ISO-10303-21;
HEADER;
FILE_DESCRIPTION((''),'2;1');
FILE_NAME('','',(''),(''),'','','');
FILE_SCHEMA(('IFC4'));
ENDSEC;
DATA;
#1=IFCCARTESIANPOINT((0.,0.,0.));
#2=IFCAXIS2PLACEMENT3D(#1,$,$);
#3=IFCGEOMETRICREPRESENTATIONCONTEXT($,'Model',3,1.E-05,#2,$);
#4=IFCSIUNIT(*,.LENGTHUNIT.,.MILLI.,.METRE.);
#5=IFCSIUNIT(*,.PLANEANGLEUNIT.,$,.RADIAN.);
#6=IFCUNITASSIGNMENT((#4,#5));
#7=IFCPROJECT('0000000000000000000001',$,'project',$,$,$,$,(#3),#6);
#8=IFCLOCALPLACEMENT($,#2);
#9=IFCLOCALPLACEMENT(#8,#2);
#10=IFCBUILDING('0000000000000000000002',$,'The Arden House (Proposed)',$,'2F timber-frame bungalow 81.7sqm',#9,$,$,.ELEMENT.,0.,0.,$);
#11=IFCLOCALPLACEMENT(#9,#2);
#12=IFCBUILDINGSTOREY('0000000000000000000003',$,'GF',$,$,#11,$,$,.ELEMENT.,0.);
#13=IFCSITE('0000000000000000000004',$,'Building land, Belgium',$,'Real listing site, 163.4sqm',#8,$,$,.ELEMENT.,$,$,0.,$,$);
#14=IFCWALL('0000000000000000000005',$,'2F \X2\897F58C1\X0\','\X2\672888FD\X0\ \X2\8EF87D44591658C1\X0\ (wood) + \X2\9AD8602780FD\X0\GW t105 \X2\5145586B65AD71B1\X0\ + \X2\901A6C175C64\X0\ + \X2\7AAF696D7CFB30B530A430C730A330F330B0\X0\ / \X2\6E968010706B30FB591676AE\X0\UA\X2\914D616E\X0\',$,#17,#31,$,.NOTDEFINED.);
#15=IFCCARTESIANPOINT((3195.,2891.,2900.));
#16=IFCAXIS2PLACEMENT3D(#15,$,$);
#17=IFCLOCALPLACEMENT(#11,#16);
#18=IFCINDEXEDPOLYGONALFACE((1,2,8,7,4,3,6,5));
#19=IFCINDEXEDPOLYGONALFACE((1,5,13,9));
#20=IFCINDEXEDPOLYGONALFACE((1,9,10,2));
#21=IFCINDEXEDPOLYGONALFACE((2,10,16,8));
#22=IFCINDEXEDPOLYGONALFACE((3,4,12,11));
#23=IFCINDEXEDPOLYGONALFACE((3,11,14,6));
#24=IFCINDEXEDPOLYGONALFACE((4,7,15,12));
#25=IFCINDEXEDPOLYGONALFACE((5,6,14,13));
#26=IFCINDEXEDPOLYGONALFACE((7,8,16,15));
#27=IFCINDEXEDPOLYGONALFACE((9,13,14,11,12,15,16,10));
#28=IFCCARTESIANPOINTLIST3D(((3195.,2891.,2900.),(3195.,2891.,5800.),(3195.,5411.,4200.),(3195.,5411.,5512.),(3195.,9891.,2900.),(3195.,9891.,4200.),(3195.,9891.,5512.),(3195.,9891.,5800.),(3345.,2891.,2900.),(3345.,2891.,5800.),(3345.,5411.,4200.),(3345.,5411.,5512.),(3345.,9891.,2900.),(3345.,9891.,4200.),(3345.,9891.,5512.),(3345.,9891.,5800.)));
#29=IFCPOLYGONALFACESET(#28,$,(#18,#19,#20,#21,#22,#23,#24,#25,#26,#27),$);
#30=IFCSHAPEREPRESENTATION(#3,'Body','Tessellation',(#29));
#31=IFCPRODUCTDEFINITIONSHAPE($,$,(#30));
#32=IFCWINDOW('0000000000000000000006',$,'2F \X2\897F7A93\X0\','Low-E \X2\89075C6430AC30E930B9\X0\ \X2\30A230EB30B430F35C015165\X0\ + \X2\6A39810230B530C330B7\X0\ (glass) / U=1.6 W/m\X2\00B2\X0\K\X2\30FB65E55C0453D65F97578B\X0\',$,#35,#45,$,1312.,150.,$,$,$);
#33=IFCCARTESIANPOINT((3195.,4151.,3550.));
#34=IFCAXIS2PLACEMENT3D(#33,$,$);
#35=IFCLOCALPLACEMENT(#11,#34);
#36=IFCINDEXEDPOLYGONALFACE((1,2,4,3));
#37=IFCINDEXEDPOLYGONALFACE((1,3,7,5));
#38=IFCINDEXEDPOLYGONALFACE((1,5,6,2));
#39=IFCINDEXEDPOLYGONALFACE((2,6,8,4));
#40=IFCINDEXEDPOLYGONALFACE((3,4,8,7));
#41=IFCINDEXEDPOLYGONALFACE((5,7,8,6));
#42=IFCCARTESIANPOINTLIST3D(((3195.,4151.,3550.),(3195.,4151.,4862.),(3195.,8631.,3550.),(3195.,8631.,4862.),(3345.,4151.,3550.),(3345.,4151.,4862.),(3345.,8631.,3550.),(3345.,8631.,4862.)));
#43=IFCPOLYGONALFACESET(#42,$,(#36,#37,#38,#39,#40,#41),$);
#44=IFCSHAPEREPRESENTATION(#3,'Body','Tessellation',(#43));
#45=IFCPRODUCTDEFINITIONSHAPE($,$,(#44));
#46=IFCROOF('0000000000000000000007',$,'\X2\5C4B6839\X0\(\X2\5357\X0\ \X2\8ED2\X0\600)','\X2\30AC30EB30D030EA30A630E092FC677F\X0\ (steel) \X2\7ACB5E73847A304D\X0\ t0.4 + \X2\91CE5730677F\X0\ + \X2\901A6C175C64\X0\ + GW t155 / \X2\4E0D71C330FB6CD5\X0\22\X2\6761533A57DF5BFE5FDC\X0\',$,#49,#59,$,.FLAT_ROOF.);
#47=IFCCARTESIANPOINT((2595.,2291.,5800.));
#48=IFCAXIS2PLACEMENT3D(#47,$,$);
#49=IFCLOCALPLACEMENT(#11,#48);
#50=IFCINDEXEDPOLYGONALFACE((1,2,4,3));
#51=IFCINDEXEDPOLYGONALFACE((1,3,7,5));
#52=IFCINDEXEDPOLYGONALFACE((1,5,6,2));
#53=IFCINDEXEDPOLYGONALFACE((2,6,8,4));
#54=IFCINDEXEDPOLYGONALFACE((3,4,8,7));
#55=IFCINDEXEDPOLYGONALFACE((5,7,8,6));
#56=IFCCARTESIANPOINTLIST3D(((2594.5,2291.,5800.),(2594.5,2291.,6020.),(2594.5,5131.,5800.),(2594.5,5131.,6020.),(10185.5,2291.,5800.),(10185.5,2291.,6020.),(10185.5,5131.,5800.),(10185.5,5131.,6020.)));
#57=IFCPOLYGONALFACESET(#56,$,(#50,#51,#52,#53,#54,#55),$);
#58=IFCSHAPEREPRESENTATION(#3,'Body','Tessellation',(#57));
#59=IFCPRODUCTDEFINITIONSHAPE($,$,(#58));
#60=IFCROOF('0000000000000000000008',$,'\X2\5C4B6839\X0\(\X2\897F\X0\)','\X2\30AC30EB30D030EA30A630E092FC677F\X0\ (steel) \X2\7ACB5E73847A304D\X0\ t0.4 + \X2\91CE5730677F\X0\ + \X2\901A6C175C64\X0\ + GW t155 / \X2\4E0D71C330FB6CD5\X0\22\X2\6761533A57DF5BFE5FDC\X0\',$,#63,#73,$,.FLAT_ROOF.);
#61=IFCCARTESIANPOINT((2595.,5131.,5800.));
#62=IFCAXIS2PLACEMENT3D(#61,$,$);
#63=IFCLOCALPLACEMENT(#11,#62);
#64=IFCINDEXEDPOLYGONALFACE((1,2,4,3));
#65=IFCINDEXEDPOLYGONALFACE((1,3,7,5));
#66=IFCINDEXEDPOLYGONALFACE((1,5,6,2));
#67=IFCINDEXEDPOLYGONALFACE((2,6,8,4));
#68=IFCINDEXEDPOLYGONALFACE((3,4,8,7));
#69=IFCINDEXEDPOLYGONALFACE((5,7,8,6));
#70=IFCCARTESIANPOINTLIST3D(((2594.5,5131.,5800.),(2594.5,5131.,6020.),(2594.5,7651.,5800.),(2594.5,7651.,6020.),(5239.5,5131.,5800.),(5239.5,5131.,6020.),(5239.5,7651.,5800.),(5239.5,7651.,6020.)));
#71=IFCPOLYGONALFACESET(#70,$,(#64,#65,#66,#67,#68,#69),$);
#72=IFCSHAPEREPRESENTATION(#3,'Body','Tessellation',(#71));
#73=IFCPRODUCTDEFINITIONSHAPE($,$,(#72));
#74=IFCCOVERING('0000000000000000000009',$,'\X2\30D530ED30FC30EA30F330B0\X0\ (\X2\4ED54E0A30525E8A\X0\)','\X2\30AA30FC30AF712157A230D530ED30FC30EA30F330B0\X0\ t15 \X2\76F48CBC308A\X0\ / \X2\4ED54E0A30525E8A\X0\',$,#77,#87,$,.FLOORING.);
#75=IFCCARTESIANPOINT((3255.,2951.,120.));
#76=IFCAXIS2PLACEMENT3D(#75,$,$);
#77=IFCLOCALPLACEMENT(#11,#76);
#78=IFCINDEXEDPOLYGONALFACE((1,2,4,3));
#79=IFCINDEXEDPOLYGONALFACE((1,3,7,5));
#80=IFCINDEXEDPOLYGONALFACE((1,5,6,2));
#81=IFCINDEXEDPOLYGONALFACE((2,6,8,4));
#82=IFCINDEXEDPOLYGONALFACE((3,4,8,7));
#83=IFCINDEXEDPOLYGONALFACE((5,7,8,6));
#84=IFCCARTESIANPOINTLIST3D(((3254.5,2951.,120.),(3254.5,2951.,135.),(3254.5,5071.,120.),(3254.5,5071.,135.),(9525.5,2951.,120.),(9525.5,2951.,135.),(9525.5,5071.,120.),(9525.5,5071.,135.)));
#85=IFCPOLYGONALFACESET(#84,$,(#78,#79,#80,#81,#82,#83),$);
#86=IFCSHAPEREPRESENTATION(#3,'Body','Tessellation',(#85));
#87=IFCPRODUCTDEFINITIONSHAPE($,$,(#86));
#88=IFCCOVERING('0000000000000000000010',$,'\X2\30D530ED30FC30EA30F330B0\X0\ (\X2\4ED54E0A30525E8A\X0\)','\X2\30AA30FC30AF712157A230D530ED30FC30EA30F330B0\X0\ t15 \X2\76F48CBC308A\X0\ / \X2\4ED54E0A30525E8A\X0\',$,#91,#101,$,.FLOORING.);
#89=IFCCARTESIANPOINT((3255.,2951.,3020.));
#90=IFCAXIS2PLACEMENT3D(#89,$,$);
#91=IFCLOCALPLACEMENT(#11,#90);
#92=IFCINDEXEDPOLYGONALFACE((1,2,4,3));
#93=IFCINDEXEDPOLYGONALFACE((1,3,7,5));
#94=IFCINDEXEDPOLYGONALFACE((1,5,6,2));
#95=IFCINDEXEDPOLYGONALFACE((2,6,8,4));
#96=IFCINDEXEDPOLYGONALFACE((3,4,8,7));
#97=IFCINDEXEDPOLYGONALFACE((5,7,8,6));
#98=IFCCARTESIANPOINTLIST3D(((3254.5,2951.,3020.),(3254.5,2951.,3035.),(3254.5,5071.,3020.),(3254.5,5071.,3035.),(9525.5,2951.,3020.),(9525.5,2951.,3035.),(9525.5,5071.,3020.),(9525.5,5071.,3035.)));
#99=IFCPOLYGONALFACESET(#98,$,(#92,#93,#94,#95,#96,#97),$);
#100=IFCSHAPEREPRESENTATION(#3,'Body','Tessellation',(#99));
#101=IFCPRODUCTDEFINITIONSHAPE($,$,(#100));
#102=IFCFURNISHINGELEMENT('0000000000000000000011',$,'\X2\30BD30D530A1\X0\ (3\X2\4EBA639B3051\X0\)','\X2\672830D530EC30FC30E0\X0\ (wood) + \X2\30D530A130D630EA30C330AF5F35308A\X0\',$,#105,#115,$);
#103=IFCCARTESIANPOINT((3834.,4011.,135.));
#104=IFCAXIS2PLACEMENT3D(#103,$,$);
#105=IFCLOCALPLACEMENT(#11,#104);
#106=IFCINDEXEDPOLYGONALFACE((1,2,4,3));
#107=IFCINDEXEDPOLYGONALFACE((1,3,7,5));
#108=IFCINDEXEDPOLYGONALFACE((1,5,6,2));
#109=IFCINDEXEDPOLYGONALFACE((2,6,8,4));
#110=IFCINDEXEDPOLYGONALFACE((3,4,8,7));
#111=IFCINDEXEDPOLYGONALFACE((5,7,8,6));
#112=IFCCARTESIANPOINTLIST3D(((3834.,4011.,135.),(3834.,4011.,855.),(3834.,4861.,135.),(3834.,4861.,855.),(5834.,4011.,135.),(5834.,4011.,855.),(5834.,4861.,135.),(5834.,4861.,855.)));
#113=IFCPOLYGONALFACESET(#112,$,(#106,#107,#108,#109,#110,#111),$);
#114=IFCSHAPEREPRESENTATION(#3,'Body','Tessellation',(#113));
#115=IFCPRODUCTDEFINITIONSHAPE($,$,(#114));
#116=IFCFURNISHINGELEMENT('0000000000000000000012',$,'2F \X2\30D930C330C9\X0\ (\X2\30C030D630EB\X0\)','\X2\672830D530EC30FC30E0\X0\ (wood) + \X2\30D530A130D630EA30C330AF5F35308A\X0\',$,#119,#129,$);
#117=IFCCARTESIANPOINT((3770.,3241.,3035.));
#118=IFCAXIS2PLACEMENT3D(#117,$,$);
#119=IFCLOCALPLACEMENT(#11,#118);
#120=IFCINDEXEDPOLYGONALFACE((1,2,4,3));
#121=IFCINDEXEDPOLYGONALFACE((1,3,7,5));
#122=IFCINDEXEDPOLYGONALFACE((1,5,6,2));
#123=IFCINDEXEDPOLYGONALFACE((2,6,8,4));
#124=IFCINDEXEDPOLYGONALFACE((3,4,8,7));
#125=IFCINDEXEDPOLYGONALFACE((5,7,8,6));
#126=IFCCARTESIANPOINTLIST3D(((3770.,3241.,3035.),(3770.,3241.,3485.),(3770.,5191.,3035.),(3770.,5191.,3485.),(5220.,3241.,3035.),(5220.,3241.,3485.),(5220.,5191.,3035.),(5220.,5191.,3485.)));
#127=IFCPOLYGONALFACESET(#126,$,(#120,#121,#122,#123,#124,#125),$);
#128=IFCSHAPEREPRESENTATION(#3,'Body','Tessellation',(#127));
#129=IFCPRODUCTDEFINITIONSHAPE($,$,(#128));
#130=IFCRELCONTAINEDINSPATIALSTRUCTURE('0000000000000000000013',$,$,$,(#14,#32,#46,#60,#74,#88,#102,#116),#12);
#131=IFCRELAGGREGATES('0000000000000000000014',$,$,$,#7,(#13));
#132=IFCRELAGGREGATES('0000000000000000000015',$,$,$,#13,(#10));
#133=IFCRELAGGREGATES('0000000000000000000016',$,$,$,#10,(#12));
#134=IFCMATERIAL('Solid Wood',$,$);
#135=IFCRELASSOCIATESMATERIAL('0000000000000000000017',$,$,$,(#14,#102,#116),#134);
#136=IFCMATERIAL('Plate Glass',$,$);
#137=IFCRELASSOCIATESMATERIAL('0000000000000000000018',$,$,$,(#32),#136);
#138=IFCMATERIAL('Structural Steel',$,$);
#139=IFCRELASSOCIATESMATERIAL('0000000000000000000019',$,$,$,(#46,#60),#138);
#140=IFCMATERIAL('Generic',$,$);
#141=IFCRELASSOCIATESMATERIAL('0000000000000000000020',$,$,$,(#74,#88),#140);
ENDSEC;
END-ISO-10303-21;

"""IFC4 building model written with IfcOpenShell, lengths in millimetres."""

from ifc_helpers import new_model, si_unit, frame, frame_2d, origin, place, context, project, spatial, rectangle, extrude, material, element, fill, save


model = new_model("IFC4")

# Units and contexts
model_context = context("Model", 3, precision=1e-05, world=origin())
ifc_project = project(units=[si_unit("LENGTHUNIT", "METRE", prefix="MILLI"), si_unit("PLANEANGLEUNIT", "RADIAN")], contexts=[model_context])

# Site, building, storey
site_placement = place(None, origin())
site = spatial("IfcSite", under=ifc_project, at=site_placement, Name="Building land, Belgium", ObjectType="Real listing site, 163.4sqm", CompositionType="ELEMENT", RefElevation=0.0)
building_placement = place(site_placement, origin())
building = spatial("IfcBuilding", under=site, at=building_placement, Name="The Arden House (Proposed)", ObjectType="2F timber-frame bungalow 81.7sqm", CompositionType="ELEMENT", ElevationOfRefHeight=0.0, ElevationOfTerrain=0.0)
storey_placement = place(building_placement, origin())
storey = spatial("IfcBuildingStorey", under=building, at=storey_placement, Name="GF", CompositionType="ELEMENT", Elevation=0.0)

# Shared definitions
ifc_material_1 = material(Name="Solid Wood")

# Shared definitions
ifc_material_2 = material(Name="Plate Glass")

# Wall, opening, window
wall_1_placement = place(storey_placement, frame((3195.0, 2891.0, 2900.0)))
wall_1 = element("IfcWall", 1, at=wall_1_placement, inside=storey, material=ifc_material_1, Name="2F 西壁", Description="木製 軸組外壁 (wood) + 高性能GW t105 充填断熱 + 通気層 + 窯業系サイディング / 準耐火・外皮UA配慮", PredefinedType="NOTDEFINED", context=model_context, shape_type="SweptSolid", body=[
    extrude(rectangle(XDim=150.0, YDim=7000.0, at=frame_2d((75.0, 3500.0))), frame((3195.0, 2891.0, 2900.0)), (0.0, 0.0, 1.0), 2900.0),
])
opening_1_placement = place(storey_placement, frame((3195.0, 4151.0, 3550.0)))
opening_1 = element("IfcOpeningElement", 2, at=opening_1_placement, cuts=wall_1, PredefinedType="NOTDEFINED", context=model_context, shape_type="SweptSolid", body=[
    extrude(rectangle(XDim=150.0, YDim=4480.0, at=frame_2d((75.0, 2240.0))), frame((3195.0, 4151.0, 3550.0)), (0.0, 0.0, 1.0), 1312.0),
])
window_1_placement = place(storey_placement, frame((3195.0, 4151.0, 3550.0)))
window_1 = element("IfcWindow", 3, at=window_1_placement, inside=storey, material=ifc_material_2, Name="2F 西窓", Description="Low-E 複層ガラス アルゴン封入 + 樹脂サッシ (glass) / U=1.6 W/m²K・日射取得型", OverallHeight=1312.0, OverallWidth=150.0, context=model_context, shape_type="SweptSolid", body=[
    extrude(rectangle(XDim=150.0, YDim=4480.0, at=frame_2d((75.0, 2240.0))), frame((3195.0, 4151.0, 3550.0)), (0.0, 0.0, 1.0), 1312.0),
])
fill(opening_1, window_1)

# Roofs
ifc_material_3 = material(Name="Structural Steel")
roof_1_placement = place(storey_placement, frame((2595.0, 2291.0, 5800.0)))
element("IfcRoof", 4, at=roof_1_placement, inside=storey, material=ifc_material_3, Name="屋根(南 軒600)", Description="ガルバリウム鋼板 (steel) 立平葺き t0.4 + 野地板 + 通気層 + GW t155 / 不燃・法22条区域対応", PredefinedType="FLAT_ROOF", context=model_context, shape_type="SweptSolid", body=[
    extrude(rectangle(XDim=7591.0, YDim=2840.0, at=frame_2d((3795.0, 1420.0))), frame((2595.0, 2291.0, 5800.0)), (0.0, 0.0, 1.0), 220.0),
])
roof_2_placement = place(storey_placement, frame((2595.0, 5131.0, 5800.0)))
element("IfcRoof", 5, at=roof_2_placement, inside=storey, material=ifc_material_3, Name="屋根(西)", Description="ガルバリウム鋼板 (steel) 立平葺き t0.4 + 野地板 + 通気層 + GW t155 / 不燃・法22条区域対応", PredefinedType="FLAT_ROOF", context=model_context, shape_type="SweptSolid", body=[
    extrude(rectangle(XDim=2645.0, YDim=2520.0, at=frame_2d((1322.0, 1260.0))), frame((2595.0, 5131.0, 5800.0)), (0.0, 0.0, 1.0), 220.0),
])

# Coverings
ifc_material_4 = material(Name="Generic")
covering_1_placement = place(storey_placement, frame((3255.0, 2951.0, 120.0)))
element("IfcCovering", 6, at=covering_1_placement, inside=storey, material=ifc_material_4, Name="フローリング (仕上げ床)", Description="オーク無垢フローリング t15 直貼り / 仕上げ床", PredefinedType="FLOORING", context=model_context, shape_type="SweptSolid", body=[
    extrude(rectangle(XDim=6271.0, YDim=2120.0, at=frame_2d((3135.0, 1060.0))), frame((3255.0, 2951.0, 120.0)), (0.0, 0.0, 1.0), 15.0),
])
covering_2_placement = place(storey_placement, frame((3255.0, 2951.0, 3020.0)))
element("IfcCovering", 7, at=covering_2_placement, inside=storey, material=ifc_material_4, Name="フローリング (仕上げ床)", Description="オーク無垢フローリング t15 直貼り / 仕上げ床", PredefinedType="FLOORING", context=model_context, shape_type="SweptSolid", body=[
    extrude(rectangle(XDim=6271.0, YDim=2120.0, at=frame_2d((3135.0, 1060.0))), frame((3255.0, 2951.0, 3020.0)), (0.0, 0.0, 1.0), 15.0),
])

# Furnishing elements
furnishing_1_placement = place(storey_placement, frame((3834.0, 4011.0, 135.0)))
element("IfcFurnishingElement", 8, at=furnishing_1_placement, inside=storey, material=ifc_material_1, Name="ソファ (3人掛け)", Description="木フレーム (wood) + ファブリック張り", context=model_context, shape_type="SweptSolid", body=[
    extrude(rectangle(XDim=2000.0, YDim=850.0, at=frame_2d((1000.0, 425.0))), frame((3834.0, 4011.0, 135.0)), (0.0, 0.0, 1.0), 720.0),
])
furnishing_2_placement = place(storey_placement, frame((3770.0, 3241.0, 3035.0)))
element("IfcFurnishingElement", 9, at=furnishing_2_placement, inside=storey, material=ifc_material_1, Name="2F ベッド (ダブル)", Description="木フレーム (wood) + ファブリック張り", context=model_context, shape_type="SweptSolid", body=[
    extrude(rectangle(XDim=1450.0, YDim=1950.0, at=frame_2d((725.0, 975.0))), frame((3770.0, 3241.0, 3035.0)), (0.0, 0.0, 1.0), 450.0),
])

save(model, "model.ifc")
